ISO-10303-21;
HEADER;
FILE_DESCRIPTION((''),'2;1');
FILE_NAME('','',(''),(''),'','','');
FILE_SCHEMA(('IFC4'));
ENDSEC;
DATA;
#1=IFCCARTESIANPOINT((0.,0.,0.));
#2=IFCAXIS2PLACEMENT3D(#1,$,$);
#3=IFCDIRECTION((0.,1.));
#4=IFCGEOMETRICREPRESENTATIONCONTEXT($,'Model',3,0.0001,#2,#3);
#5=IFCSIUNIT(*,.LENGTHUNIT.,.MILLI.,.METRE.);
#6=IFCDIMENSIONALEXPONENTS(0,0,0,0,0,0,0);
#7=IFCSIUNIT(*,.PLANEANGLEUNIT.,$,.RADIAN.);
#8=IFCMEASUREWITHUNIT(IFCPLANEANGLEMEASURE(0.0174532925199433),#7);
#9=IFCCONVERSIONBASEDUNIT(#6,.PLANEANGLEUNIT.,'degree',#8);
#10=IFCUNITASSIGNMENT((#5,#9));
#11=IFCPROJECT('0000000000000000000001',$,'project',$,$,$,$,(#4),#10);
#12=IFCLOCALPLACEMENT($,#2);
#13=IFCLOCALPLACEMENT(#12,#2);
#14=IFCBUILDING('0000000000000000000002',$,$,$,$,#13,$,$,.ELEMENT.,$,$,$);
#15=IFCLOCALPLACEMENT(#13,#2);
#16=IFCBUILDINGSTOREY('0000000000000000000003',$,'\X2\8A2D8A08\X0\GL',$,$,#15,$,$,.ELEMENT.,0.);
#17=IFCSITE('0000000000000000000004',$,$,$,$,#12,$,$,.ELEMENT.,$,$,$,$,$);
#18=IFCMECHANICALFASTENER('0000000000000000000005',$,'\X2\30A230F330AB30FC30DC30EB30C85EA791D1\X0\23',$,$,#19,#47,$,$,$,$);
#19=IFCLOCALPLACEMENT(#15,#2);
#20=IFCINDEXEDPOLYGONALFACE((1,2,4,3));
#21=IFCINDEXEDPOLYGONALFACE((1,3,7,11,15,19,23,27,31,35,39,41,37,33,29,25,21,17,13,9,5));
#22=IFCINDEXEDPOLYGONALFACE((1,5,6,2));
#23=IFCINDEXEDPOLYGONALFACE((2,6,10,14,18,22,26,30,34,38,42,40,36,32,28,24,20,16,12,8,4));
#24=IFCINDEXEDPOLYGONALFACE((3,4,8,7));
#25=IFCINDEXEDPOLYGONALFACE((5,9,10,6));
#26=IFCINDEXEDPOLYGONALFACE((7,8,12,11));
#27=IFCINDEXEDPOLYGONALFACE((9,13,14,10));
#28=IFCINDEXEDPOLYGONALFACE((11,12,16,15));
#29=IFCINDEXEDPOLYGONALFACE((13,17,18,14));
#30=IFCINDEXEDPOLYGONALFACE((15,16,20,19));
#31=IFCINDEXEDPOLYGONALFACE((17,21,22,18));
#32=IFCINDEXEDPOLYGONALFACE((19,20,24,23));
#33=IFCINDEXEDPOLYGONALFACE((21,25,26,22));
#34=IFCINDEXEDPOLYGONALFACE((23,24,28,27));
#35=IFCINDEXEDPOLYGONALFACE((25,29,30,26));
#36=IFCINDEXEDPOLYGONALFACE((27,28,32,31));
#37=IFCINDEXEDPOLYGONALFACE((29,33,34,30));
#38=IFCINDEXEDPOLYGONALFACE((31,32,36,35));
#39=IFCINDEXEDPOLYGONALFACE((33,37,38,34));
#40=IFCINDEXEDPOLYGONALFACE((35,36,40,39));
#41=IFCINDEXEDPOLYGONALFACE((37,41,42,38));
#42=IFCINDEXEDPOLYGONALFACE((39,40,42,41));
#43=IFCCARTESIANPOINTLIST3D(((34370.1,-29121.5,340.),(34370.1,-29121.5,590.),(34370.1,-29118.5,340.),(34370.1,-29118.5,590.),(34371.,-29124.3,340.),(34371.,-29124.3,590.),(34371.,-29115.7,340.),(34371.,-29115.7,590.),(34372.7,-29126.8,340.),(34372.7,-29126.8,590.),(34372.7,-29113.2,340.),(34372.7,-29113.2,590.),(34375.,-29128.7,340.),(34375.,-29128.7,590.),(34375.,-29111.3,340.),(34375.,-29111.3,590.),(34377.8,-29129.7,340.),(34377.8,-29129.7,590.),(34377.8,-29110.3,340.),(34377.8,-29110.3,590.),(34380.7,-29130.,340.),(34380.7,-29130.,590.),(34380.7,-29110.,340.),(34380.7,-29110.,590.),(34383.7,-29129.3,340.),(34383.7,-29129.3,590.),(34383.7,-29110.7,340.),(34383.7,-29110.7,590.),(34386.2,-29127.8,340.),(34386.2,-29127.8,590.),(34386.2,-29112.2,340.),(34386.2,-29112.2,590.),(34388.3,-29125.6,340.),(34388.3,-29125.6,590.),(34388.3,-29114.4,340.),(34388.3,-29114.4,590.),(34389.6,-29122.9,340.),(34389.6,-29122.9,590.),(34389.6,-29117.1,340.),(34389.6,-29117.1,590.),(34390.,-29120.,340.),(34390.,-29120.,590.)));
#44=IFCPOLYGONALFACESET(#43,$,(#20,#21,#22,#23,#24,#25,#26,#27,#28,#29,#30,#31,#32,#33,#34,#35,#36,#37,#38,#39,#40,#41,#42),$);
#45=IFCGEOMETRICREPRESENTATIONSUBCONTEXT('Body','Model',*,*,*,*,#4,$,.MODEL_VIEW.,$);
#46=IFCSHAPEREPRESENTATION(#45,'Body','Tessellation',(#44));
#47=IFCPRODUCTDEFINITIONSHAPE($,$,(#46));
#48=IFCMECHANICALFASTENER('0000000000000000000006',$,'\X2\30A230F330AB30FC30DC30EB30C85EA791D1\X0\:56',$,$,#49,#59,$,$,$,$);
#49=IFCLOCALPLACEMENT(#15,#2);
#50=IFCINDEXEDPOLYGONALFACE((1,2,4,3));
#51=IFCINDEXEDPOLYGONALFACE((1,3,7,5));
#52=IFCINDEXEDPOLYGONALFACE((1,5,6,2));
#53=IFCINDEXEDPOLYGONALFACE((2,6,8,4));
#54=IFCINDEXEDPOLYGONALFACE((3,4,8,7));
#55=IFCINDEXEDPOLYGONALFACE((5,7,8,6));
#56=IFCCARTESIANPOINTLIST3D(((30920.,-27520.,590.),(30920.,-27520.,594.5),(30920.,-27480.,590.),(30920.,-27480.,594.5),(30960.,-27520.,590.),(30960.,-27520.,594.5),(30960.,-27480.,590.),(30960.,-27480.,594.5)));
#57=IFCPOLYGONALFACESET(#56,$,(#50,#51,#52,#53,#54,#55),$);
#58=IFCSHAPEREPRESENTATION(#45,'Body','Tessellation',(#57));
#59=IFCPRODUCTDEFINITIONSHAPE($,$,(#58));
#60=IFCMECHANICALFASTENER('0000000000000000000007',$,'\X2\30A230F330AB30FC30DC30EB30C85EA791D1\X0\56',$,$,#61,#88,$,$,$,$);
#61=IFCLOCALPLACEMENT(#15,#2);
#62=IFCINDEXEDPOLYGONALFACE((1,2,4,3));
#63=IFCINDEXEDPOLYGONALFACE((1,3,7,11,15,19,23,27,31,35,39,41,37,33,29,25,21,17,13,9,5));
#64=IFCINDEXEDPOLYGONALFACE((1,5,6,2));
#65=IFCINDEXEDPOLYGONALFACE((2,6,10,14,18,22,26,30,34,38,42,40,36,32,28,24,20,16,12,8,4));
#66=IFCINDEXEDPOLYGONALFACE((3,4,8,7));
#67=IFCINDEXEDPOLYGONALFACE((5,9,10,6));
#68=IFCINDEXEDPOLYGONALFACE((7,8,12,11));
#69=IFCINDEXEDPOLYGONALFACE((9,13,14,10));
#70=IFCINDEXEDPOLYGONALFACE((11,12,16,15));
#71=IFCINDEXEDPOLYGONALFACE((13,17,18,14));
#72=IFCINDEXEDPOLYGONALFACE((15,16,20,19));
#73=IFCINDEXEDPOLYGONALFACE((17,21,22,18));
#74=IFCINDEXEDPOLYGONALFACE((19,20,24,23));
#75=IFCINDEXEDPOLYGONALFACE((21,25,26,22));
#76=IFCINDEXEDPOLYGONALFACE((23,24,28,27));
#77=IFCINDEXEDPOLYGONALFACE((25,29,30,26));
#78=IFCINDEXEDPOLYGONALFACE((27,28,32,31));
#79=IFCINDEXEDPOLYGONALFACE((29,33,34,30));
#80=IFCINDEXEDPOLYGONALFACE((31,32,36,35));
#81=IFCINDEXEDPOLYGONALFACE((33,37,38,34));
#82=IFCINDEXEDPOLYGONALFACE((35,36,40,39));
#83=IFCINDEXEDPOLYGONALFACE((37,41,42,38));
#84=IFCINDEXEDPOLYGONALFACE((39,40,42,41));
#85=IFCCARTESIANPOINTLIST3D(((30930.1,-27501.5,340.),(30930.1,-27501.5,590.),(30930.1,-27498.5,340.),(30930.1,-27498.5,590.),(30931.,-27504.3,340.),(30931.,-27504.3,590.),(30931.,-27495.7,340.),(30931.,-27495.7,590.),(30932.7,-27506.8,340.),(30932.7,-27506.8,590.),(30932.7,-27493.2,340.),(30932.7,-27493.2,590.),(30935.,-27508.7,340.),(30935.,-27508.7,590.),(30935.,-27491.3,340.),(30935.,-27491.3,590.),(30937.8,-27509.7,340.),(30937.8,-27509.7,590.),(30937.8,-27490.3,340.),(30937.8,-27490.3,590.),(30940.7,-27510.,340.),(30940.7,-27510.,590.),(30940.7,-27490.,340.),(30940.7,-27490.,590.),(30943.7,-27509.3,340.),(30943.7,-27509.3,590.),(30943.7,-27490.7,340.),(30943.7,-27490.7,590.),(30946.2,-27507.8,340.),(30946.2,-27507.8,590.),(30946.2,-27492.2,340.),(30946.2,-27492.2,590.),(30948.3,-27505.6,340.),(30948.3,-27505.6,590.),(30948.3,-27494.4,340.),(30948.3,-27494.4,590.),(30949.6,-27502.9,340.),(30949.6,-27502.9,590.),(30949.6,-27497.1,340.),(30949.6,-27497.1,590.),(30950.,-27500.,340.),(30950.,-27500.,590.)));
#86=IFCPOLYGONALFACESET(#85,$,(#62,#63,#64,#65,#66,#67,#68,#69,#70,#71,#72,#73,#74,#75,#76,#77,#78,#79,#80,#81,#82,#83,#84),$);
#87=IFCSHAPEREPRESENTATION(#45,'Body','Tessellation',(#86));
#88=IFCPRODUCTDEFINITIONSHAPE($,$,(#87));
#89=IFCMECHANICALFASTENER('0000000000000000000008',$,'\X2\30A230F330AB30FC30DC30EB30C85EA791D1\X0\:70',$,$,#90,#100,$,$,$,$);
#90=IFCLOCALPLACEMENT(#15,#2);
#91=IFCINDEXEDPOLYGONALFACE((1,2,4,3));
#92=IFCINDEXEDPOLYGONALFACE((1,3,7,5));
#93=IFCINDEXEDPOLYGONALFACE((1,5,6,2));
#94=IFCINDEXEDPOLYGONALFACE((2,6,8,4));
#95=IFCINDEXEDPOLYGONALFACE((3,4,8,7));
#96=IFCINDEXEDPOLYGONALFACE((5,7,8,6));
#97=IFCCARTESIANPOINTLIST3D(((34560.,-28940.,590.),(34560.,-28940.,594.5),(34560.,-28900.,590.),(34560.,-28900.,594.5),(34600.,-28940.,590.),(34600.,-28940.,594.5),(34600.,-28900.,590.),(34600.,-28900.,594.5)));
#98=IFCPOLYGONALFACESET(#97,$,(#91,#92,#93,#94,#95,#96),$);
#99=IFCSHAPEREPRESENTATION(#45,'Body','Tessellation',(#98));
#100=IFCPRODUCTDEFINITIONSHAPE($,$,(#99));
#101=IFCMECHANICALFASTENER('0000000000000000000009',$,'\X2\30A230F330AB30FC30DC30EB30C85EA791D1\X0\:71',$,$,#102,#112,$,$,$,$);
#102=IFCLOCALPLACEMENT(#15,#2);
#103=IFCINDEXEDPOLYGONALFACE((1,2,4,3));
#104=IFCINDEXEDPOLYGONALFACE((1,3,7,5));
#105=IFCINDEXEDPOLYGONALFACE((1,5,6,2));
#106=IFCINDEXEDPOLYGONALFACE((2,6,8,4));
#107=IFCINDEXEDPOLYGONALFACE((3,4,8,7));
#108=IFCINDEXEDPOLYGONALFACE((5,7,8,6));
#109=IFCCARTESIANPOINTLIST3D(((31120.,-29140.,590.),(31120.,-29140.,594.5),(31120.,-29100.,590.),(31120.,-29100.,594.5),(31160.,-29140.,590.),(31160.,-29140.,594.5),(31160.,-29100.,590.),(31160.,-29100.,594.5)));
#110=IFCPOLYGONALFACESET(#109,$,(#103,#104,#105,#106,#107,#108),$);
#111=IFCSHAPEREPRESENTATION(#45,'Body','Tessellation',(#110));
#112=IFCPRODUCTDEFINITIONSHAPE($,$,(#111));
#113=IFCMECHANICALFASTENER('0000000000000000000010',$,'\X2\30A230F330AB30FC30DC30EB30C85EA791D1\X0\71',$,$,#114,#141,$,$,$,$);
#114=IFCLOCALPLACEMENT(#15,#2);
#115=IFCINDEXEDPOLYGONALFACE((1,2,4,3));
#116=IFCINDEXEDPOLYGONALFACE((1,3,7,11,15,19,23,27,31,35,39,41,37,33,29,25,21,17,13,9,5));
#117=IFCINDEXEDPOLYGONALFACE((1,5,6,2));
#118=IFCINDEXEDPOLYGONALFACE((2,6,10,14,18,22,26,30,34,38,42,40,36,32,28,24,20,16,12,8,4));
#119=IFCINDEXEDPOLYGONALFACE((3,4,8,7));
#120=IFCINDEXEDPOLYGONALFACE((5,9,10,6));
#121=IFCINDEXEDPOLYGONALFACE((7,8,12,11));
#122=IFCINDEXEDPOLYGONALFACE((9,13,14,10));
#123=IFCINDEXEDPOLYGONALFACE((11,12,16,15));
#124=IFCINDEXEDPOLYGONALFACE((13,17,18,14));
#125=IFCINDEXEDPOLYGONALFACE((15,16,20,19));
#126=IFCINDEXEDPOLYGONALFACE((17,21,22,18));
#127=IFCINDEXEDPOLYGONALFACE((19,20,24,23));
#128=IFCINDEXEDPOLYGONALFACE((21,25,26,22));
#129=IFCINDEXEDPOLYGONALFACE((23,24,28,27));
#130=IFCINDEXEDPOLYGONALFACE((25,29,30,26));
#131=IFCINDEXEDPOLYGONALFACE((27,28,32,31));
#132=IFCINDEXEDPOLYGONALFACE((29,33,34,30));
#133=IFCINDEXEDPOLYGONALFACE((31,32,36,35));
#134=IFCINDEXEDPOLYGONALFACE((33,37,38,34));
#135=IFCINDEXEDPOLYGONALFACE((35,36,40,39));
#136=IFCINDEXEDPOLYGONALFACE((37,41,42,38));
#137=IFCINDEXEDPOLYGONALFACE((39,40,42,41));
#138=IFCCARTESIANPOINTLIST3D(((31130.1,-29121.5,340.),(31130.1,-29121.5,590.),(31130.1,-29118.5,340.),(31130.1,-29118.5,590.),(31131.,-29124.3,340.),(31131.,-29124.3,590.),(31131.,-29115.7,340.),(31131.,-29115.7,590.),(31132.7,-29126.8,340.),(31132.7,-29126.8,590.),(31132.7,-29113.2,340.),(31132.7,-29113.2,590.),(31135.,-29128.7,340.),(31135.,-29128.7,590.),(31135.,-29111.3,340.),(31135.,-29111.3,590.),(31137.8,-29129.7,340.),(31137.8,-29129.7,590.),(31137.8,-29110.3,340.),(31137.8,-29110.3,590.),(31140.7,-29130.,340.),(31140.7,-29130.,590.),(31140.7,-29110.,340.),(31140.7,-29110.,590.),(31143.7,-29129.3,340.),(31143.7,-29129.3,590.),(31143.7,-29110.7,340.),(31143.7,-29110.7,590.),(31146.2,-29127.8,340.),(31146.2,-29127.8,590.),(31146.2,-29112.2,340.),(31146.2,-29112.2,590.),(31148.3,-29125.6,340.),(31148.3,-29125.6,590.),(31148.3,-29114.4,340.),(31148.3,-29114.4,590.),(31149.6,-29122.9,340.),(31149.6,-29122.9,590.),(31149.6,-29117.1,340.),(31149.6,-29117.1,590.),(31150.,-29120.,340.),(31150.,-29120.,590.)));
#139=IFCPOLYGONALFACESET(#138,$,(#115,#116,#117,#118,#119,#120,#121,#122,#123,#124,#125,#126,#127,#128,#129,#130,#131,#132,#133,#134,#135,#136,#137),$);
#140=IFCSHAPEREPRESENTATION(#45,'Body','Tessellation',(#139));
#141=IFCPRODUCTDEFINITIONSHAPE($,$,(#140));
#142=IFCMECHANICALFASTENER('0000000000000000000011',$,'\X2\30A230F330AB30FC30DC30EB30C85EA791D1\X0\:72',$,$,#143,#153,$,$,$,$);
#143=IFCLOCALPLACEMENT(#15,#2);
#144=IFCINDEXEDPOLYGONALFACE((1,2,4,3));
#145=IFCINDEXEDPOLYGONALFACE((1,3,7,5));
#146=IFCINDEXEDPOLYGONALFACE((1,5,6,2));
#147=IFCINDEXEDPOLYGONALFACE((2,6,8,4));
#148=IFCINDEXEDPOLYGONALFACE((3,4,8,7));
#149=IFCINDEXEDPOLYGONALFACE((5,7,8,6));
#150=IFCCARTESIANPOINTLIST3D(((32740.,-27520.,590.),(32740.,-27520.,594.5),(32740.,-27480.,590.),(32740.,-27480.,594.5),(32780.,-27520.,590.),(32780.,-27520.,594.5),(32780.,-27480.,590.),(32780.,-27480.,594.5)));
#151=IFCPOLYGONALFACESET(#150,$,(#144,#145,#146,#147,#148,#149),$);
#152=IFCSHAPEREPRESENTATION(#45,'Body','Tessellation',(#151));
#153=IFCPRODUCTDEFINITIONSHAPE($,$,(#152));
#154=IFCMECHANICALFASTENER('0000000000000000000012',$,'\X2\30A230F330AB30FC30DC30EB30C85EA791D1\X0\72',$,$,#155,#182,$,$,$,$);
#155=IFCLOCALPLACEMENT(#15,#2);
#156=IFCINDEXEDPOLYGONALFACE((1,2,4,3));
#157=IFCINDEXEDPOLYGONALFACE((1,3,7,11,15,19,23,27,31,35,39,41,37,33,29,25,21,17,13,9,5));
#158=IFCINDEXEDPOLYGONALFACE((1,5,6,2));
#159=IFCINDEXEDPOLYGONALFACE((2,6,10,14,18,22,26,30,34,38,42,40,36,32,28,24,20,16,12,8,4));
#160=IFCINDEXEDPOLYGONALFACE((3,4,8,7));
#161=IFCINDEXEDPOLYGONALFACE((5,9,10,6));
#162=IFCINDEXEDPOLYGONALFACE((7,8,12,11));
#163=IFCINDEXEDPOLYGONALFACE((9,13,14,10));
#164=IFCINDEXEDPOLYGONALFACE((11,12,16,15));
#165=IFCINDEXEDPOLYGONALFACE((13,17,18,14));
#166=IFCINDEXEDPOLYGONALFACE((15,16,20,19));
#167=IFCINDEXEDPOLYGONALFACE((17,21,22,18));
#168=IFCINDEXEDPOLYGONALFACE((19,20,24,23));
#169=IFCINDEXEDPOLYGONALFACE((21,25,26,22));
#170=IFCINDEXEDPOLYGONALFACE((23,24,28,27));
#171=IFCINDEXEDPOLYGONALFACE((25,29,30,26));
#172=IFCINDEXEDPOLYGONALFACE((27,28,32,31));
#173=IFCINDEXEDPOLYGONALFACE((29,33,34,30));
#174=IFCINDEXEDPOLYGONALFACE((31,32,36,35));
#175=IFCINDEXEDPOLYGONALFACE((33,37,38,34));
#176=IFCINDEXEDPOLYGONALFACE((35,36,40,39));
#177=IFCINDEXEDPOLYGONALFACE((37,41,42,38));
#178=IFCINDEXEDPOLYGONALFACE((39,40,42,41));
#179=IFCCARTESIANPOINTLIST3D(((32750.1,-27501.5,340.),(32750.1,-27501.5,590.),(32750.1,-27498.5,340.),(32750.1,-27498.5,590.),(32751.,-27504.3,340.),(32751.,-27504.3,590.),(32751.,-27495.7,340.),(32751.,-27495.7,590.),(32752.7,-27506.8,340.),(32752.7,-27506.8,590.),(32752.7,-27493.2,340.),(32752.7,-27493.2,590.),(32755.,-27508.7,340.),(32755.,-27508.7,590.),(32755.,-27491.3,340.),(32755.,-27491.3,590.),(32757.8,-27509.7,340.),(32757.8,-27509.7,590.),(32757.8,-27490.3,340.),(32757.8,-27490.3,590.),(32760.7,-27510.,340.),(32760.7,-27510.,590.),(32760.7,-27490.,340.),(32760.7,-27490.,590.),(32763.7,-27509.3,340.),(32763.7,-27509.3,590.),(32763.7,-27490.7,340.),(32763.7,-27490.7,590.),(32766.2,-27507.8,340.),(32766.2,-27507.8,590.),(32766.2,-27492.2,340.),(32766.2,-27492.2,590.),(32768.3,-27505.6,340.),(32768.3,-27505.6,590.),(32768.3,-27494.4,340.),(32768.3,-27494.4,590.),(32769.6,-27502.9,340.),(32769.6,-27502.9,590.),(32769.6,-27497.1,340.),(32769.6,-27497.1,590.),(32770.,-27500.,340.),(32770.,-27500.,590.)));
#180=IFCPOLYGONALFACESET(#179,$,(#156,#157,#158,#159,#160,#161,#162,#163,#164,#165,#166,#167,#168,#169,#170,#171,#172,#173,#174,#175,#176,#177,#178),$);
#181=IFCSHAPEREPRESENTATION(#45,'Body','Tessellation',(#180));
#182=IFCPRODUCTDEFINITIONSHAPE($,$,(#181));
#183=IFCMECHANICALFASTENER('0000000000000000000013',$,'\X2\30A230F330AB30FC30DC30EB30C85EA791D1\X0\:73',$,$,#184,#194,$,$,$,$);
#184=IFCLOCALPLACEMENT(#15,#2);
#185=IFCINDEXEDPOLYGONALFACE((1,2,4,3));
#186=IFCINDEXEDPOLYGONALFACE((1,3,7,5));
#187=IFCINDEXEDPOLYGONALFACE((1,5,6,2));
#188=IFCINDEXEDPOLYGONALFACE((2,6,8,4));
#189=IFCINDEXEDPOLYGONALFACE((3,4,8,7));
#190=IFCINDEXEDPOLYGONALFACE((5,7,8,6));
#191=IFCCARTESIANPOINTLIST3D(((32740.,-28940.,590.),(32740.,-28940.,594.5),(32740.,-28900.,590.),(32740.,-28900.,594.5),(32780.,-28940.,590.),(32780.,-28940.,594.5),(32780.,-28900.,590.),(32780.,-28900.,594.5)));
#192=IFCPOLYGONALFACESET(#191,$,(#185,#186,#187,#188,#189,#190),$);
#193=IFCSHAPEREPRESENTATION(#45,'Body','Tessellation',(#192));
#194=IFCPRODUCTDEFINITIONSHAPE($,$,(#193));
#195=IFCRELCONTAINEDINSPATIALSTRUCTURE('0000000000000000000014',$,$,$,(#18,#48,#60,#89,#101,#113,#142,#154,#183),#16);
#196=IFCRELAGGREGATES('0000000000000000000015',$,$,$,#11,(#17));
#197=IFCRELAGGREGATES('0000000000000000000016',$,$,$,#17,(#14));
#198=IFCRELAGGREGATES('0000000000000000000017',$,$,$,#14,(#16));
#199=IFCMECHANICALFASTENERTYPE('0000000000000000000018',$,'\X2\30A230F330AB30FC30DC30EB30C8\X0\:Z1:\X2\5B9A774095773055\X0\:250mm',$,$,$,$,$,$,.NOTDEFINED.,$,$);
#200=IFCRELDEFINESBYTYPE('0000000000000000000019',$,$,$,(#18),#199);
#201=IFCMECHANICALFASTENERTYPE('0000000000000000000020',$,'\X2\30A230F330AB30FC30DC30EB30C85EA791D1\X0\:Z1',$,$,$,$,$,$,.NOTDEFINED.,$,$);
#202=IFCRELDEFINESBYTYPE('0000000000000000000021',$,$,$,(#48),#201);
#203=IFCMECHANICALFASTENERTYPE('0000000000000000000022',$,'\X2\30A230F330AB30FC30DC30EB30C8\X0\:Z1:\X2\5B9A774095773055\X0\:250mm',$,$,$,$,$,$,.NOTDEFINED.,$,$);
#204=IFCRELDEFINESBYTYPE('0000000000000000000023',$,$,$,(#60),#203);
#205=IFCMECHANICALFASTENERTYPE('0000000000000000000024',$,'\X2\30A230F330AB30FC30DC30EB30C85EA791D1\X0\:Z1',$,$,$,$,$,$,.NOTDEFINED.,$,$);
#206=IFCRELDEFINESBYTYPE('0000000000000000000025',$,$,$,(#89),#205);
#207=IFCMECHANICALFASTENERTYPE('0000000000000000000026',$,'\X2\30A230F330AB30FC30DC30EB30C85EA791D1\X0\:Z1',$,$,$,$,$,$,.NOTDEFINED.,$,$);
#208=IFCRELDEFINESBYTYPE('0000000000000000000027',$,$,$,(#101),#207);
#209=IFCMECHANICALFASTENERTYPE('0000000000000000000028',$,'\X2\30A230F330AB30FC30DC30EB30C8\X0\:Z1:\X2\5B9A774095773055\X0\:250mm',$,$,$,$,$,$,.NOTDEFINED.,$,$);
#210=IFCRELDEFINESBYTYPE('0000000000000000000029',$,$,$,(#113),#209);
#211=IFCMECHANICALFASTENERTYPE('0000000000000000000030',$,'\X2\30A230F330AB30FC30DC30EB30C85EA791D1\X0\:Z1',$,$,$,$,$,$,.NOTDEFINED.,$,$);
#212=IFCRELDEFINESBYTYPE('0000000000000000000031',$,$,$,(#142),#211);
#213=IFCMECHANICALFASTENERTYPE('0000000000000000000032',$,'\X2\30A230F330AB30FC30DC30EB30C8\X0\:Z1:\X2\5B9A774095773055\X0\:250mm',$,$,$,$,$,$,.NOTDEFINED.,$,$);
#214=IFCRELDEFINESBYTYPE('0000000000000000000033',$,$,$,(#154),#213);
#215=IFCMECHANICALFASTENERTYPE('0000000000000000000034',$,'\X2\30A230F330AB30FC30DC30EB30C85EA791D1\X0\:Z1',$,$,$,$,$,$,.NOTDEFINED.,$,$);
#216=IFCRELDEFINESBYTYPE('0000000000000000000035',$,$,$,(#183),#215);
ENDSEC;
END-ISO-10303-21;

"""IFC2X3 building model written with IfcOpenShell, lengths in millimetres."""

from ifc_helpers import new_model, entity, si_unit, converted_unit, direction, frame, origin, origin_with_axes, origin_2d, place, context, subcontext, project, spatial, rectangle, circle, extrude, type_object, element, save


model = new_model("IFC2X3")

# Units and contexts
model_context = context("Model", 3, precision=0.0001, world=origin(), true_north=direction((0.0, 1.0)))
body_context = subcontext(model_context, "Body", "Model", "MODEL_VIEW")
ifc_project = project(units=[si_unit("LENGTHUNIT", "METRE", prefix="MILLI"), converted_unit("PLANEANGLEUNIT", "degree", entity("IfcPlaneAngleMeasure", 0.0174532925199433), si_unit("PLANEANGLEUNIT", "RADIAN"), dimensions=[0, 0, 0, 0, 0, 0, 0])], contexts=[model_context])

# Site, building, storey
site_placement = place(None, origin())
site = spatial("IfcSite", under=ifc_project, at=site_placement, CompositionType="ELEMENT")
building_placement = place(site_placement, origin())
building = spatial("IfcBuilding", under=site, at=building_placement, CompositionType="ELEMENT")
storey_placement = place(building_placement, origin())
storey = spatial("IfcBuildingStorey", under=building, at=storey_placement, Name="設計GL", CompositionType="ELEMENT", Elevation=0.0)

# Mechanical fasteners
mechanical_fastener_type_1 = type_object("IfcMechanicalFastenerType", Name="アンカーボルト:Z1:定着長さ:250mm")
mechanical_fastener_1_placement = place(storey_placement, frame((34380.0, -29120.0, 340.0)))
element("IfcMechanicalFastener", 1, at=mechanical_fastener_1_placement, inside=storey, type_object=mechanical_fastener_type_1, Name="アンカーボルト座金23", context=body_context, shape_type="SweptSolid", body=[
    extrude(circle(Radius=10.0, at=origin_2d()), origin_with_axes(), (0.0, 0.0, 1.0), 250.0),
])
mechanical_fastener_type_2 = type_object("IfcMechanicalFastenerType", Name="アンカーボルト座金:Z1")
mechanical_fastener_2_placement = place(storey_placement, frame((30940.0, -27500.0, 590.0)))
element("IfcMechanicalFastener", 2, at=mechanical_fastener_2_placement, inside=storey, type_object=mechanical_fastener_type_2, Name="アンカーボルト座金:56", context=body_context, shape_type="SweptSolid", body=[
    extrude(rectangle(XDim=40.0, YDim=40.0, at=origin_2d()), origin_with_axes(), (0.0, 0.0, 1.0), 4.5),
])
mechanical_fastener_type_3 = type_object("IfcMechanicalFastenerType", Name="アンカーボルト:Z1:定着長さ:250mm")
mechanical_fastener_3_placement = place(storey_placement, frame((30940.0, -27500.0, 340.0)))
element("IfcMechanicalFastener", 3, at=mechanical_fastener_3_placement, inside=storey, type_object=mechanical_fastener_type_3, Name="アンカーボルト座金56", context=body_context, shape_type="SweptSolid", body=[
    extrude(circle(Radius=10.0, at=origin_2d()), origin_with_axes(), (0.0, 0.0, 1.0), 250.0),
])
mechanical_fastener_type_4 = type_object("IfcMechanicalFastenerType", Name="アンカーボルト座金:Z1")
mechanical_fastener_4_placement = place(storey_placement, frame((34580.0, -28920.0, 590.0)))
element("IfcMechanicalFastener", 4, at=mechanical_fastener_4_placement, inside=storey, type_object=mechanical_fastener_type_4, Name="アンカーボルト座金:70", context=body_context, shape_type="SweptSolid", body=[
    extrude(rectangle(XDim=40.0, YDim=40.0, at=origin_2d()), origin_with_axes(), (0.0, 0.0, 1.0), 4.5),
])
mechanical_fastener_type_5 = type_object("IfcMechanicalFastenerType", Name="アンカーボルト座金:Z1")
mechanical_fastener_5_placement = place(storey_placement, frame((31140.0, -29120.0, 590.0)))
element("IfcMechanicalFastener", 5, at=mechanical_fastener_5_placement, inside=storey, type_object=mechanical_fastener_type_5, Name="アンカーボルト座金:71", context=body_context, shape_type="SweptSolid", body=[
    extrude(rectangle(XDim=40.0, YDim=40.0, at=origin_2d()), origin_with_axes(), (0.0, 0.0, 1.0), 4.5),
])
mechanical_fastener_type_6 = type_object("IfcMechanicalFastenerType", Name="アンカーボルト:Z1:定着長さ:250mm")
mechanical_fastener_6_placement = place(storey_placement, frame((31140.0, -29120.0, 340.0)))
element("IfcMechanicalFastener", 6, at=mechanical_fastener_6_placement, inside=storey, type_object=mechanical_fastener_type_6, Name="アンカーボルト座金71", context=body_context, shape_type="SweptSolid", body=[
    extrude(circle(Radius=10.0, at=origin_2d()), origin_with_axes(), (0.0, 0.0, 1.0), 250.0),
])
mechanical_fastener_type_7 = type_object("IfcMechanicalFastenerType", Name="アンカーボルト座金:Z1")
mechanical_fastener_7_placement = place(storey_placement, frame((32760.0, -27500.0, 590.0)))
element("IfcMechanicalFastener", 7, at=mechanical_fastener_7_placement, inside=storey, type_object=mechanical_fastener_type_7, Name="アンカーボルト座金:72", context=body_context, shape_type="SweptSolid", body=[
    extrude(rectangle(XDim=40.0, YDim=40.0, at=origin_2d()), origin_with_axes(), (0.0, 0.0, 1.0), 4.5),
])
mechanical_fastener_type_8 = type_object("IfcMechanicalFastenerType", Name="アンカーボルト:Z1:定着長さ:250mm")
mechanical_fastener_8_placement = place(storey_placement, frame((32760.0, -27500.0, 340.0)))
element("IfcMechanicalFastener", 8, at=mechanical_fastener_8_placement, inside=storey, type_object=mechanical_fastener_type_8, Name="アンカーボルト座金72", context=body_context, shape_type="SweptSolid", body=[
    extrude(circle(Radius=10.0, at=origin_2d()), origin_with_axes(), (0.0, 0.0, 1.0), 250.0),
])
mechanical_fastener_type_9 = type_object("IfcMechanicalFastenerType", Name="アンカーボルト座金:Z1")
mechanical_fastener_9_placement = place(storey_placement, frame((32760.0, -28920.0, 590.0)))
element("IfcMechanicalFastener", 9, at=mechanical_fastener_9_placement, inside=storey, type_object=mechanical_fastener_type_9, Name="アンカーボルト座金:73", context=body_context, shape_type="SweptSolid", body=[
    extrude(rectangle(XDim=40.0, YDim=40.0, at=origin_2d()), origin_with_axes(), (0.0, 0.0, 1.0), 4.5),
])

save(model, "model.ifc")
